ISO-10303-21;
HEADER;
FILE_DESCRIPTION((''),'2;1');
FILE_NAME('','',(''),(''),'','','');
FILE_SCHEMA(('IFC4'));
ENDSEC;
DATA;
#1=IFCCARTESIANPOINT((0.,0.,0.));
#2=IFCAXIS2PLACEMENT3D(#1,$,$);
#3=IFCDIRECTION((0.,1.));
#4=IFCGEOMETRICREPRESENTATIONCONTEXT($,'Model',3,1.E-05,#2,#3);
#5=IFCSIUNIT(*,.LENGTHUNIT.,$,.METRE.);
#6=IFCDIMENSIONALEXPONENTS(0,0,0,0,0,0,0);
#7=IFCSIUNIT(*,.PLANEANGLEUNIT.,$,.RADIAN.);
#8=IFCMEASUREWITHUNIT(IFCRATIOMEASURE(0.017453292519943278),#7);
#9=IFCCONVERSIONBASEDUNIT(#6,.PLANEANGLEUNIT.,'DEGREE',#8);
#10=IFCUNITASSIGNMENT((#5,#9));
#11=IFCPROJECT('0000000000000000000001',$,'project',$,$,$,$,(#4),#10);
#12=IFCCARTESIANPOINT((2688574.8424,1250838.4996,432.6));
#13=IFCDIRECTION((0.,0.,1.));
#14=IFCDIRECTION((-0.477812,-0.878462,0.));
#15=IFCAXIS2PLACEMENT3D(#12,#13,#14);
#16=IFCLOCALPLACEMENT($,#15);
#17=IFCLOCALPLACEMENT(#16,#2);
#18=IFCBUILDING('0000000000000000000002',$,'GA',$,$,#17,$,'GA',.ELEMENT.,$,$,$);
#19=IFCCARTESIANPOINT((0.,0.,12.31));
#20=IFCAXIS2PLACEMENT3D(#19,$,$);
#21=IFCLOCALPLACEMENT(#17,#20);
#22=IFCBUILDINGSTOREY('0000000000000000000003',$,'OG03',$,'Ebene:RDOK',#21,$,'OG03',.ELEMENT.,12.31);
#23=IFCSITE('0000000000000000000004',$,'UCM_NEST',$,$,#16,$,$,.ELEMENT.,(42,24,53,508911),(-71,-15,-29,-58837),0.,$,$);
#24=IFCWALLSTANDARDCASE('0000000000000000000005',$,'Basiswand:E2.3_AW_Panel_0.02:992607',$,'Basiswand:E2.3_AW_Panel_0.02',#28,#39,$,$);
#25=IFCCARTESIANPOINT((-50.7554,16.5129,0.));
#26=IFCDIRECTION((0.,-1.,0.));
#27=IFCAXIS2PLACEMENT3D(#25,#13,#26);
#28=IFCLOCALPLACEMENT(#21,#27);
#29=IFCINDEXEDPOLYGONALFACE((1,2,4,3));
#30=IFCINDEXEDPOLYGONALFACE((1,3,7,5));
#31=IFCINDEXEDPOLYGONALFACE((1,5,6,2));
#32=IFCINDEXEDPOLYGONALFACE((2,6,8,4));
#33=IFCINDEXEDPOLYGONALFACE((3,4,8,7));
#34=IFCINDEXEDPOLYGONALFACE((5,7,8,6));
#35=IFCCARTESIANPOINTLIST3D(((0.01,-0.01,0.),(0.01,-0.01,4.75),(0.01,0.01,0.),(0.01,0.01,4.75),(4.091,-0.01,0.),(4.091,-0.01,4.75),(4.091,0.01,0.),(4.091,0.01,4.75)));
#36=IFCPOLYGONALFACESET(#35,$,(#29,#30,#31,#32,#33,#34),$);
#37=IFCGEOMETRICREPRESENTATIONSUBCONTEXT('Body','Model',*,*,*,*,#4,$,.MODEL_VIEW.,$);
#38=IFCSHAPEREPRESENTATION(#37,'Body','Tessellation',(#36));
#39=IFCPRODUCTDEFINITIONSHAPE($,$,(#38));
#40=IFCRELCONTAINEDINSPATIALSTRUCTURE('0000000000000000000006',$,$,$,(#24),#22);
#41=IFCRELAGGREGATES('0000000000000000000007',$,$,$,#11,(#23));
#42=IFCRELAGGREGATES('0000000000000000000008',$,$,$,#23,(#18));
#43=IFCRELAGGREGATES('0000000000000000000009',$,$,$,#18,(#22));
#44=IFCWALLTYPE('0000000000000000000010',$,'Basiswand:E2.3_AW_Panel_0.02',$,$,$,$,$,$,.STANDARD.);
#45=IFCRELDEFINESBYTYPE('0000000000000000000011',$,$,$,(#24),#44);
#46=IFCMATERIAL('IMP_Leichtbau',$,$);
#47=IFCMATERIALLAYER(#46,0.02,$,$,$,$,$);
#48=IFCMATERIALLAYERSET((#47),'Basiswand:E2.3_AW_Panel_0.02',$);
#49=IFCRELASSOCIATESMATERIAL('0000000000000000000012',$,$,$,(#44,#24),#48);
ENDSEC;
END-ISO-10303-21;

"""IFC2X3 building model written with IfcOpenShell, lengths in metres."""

from ifc_helpers import new_model, entity, si_unit, converted_unit, direction, frame, frame_2d, origin, place, context, subcontext, project, spatial, rectangle, extrude, material, layer, layer_set, layer_usage, type_object, element, save


model = new_model("IFC2X3")

# Units and contexts
model_context = context("Model", 3, precision=1e-05, world=origin(), true_north=direction((0.0, 1.0)))
body_context = subcontext(model_context, "Body", "Model", "MODEL_VIEW")
ifc_project = project(units=[si_unit("LENGTHUNIT", "METRE"), converted_unit("PLANEANGLEUNIT", "DEGREE", entity("IfcRatioMeasure", 0.017453292519943278), si_unit("PLANEANGLEUNIT", "RADIAN"), dimensions=[0, 0, 0, 0, 0, 0, 0])], contexts=[model_context])

# Site, building, storey
site_placement = place(None, frame((2688574.8424, 1250838.4996, 432.6), z_axis=(0.0, 0.0, 1.0), x_axis=(-0.477812, -0.878462, 0.0)))
site = spatial("IfcSite", under=ifc_project, at=site_placement, Name="UCM_NEST", CompositionType="ELEMENT", RefLatitude=(42, 24, 53, 508911), RefLongitude=(-71, -15, -29, -58837), RefElevation=0.0)
building_placement = place(site_placement, origin())
building = spatial("IfcBuilding", under=site, at=building_placement, Name="GA", LongName="GA", CompositionType="ELEMENT")
storey_placement = place(building_placement, frame((0.0, 0.0, 12.31)))
storey = spatial("IfcBuildingStorey", under=building, at=storey_placement, Name="OG03", ObjectType="Ebene:RDOK", LongName="OG03", CompositionType="ELEMENT", Elevation=12.31)

# Wall
ifc_material_1 = material(Name="IMP_Leichtbau")
ifc_layer_1 = layer(ifc_material_1, 0.02)
ifc_layer_set_1 = layer_set([ifc_layer_1], Name="Basiswand:E2.3_AW_Panel_0.02")
ifc_layer_usage_1 = layer_usage(ifc_layer_set_1, "AXIS2", "NEGATIVE", 0.01)
wall_type_1 = type_object("IfcWallType", Name="Basiswand:E2.3_AW_Panel_0.02", PredefinedType="STANDARD", material=ifc_layer_set_1)
wall_1_placement = place(storey_placement, frame((-50.7554, 16.5129, 0.0), z_axis=(0.0, 0.0, 1.0), x_axis=(0.0, -1.0, 0.0)))
element("IfcWallStandardCase", 1, at=wall_1_placement, inside=storey, type_object=wall_type_1, material=ifc_layer_usage_1, Name="Basiswand:E2.3_AW_Panel_0.02:992607", ObjectType="Basiswand:E2.3_AW_Panel_0.02", context=body_context, shape_type="SweptSolid", body=[
    extrude(rectangle(XDim=4.081, YDim=0.02, at=frame_2d((2.0505, 0.0), x_axis=(-1.0, 0.0))), origin(), (0.0, 0.0, 1.0), 4.75),
])

save(model, "model.ifc")
